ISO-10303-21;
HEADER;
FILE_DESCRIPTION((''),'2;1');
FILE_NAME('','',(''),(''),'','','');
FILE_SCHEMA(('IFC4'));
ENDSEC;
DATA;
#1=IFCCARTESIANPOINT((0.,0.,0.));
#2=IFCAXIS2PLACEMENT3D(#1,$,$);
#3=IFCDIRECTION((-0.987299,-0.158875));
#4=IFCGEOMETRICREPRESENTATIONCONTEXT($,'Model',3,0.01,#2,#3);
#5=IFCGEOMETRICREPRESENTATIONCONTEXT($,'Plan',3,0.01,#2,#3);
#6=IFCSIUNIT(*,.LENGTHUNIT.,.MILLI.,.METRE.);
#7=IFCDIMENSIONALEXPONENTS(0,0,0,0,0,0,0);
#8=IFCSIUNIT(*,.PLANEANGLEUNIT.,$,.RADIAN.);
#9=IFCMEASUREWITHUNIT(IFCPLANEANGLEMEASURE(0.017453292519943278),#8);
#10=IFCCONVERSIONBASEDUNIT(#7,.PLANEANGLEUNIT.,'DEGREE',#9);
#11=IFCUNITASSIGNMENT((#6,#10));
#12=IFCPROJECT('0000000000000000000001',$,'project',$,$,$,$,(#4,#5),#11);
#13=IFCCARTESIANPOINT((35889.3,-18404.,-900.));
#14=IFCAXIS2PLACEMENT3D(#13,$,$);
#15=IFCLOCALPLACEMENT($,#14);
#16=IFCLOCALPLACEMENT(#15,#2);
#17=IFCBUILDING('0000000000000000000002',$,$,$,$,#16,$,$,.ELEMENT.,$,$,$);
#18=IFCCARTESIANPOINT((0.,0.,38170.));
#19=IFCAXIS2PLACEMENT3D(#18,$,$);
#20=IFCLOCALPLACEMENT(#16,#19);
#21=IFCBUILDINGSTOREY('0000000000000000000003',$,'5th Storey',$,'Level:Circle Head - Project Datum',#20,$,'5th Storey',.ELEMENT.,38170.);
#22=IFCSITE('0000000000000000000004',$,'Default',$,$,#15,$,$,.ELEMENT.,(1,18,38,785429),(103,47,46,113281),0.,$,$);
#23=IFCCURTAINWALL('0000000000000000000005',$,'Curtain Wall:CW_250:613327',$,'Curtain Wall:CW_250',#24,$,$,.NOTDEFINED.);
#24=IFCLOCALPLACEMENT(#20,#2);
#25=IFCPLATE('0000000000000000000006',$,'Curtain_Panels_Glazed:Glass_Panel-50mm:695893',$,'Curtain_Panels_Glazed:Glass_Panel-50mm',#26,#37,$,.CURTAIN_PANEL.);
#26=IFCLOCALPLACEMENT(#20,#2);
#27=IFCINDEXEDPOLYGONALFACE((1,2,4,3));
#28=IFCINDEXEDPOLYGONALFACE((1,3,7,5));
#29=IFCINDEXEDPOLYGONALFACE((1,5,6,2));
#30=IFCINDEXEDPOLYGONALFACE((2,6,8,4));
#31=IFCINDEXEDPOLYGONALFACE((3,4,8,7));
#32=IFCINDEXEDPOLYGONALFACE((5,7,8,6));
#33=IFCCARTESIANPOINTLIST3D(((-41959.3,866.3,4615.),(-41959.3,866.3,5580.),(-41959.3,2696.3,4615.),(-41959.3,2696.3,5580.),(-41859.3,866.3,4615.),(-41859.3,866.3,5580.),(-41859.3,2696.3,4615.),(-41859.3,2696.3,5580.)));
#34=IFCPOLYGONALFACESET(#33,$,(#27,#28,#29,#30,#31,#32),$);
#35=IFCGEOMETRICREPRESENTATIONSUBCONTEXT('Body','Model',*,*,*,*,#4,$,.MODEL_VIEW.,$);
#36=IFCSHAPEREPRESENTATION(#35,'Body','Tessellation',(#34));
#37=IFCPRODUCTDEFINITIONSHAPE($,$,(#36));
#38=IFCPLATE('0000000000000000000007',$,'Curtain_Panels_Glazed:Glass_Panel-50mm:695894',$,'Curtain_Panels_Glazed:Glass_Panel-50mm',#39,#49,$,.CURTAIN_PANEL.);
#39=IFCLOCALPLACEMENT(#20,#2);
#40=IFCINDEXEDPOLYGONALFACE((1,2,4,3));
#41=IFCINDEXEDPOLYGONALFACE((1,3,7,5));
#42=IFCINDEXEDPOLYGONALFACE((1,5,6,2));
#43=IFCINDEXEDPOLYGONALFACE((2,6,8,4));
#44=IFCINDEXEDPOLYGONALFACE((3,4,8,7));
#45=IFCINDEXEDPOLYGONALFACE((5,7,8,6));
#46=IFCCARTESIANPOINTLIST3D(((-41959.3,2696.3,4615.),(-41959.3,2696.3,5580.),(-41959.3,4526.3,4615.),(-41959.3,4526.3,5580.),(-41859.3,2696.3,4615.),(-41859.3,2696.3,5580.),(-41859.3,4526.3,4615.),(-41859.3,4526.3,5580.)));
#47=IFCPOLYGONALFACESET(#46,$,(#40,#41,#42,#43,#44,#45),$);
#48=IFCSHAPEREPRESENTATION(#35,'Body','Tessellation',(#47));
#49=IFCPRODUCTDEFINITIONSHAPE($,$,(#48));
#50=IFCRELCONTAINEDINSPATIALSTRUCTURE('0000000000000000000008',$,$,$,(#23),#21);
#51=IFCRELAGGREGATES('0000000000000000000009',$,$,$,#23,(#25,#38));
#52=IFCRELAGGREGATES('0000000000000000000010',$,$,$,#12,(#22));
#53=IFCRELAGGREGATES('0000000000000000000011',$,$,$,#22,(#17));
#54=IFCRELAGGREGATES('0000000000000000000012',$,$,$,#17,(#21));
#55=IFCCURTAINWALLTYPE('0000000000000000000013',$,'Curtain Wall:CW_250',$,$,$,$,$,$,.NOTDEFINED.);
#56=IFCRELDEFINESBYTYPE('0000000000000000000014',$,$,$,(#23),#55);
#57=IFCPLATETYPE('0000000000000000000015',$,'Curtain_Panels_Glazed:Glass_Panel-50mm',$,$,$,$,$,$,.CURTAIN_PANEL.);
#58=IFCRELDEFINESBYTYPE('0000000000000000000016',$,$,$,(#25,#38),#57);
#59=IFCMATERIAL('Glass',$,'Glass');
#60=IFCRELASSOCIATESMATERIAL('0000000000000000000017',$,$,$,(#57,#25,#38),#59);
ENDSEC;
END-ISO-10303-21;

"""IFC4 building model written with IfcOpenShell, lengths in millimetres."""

from ifc_helpers import new_model, entity, si_unit, converted_unit, direction, frame, origin, place, context, subcontext, project, spatial, indexed_curve, outline, extrude, source, transform, mapped, material, type_object, type_shapes, element, aggregate, save


model = new_model("IFC4")

# Units and contexts
model_context = context("Model", 3, precision=0.01, world=origin(), true_north=direction((-0.987299, -0.158875)))
plan_context = context("Plan", 3, precision=0.01, world=origin(), true_north=direction((-0.987299, -0.158875)))
body_context = subcontext(model_context, "Body", "Model", "MODEL_VIEW")
ifc_project = project(units=[si_unit("LENGTHUNIT", "METRE", prefix="MILLI"), converted_unit("PLANEANGLEUNIT", "DEGREE", entity("IfcPlaneAngleMeasure", 0.017453292519943278), si_unit("PLANEANGLEUNIT", "RADIAN"), dimensions=[0, 0, 0, 0, 0, 0, 0])], contexts=[model_context, plan_context])

# Site, building, storey
site_placement = place(None, frame((35889.3, -18404.0, -900.0)))
site = spatial("IfcSite", under=ifc_project, at=site_placement, Name="Default", CompositionType="ELEMENT", RefLatitude=(1, 18, 38, 785429), RefLongitude=(103, 47, 46, 113281), RefElevation=0.0)
building_placement = place(site_placement, origin())
building = spatial("IfcBuilding", under=site, at=building_placement, CompositionType="ELEMENT")
storey_placement = place(building_placement, frame((0.0, 0.0, 38170.0)))
storey = spatial("IfcBuildingStorey", under=building, at=storey_placement, Name="5th Storey", ObjectType="Level:Circle Head - Project Datum", LongName="5th Storey", CompositionType="ELEMENT", Elevation=38170.0)

# Curtain wall
curtain_wall_type = type_object("IfcCurtainWallType", Name="Curtain Wall:CW_250", PredefinedType="NOTDEFINED")
curtain_wall_1_placement = place(storey_placement, frame((0.0, 0.0, -38170.0)))
curtain_wall_1 = element("IfcCurtainWall", 1, at=curtain_wall_1_placement, inside=storey, type_object=curtain_wall_type, Name="Curtain Wall:CW_250:613327", ObjectType="Curtain Wall:CW_250", PredefinedType="NOTDEFINED")

# Plates
ifc_material_1 = material(Name="Glass", Category="Glass")
plate_type_1 = type_object("IfcPlateType", Name="Curtain_Panels_Glazed:Glass_Panel-50mm", PredefinedType="CURTAIN_PANEL", material=ifc_material_1)
shared_shape_1 = source(origin(), body_context, "Body", "SweptSolid", [
    extrude(outline(indexed_curve([(-50.0, -915.0), (50.0, -915.0), (50.0, 915.0), (-50.0, 915.0), (-50.0, -915.0)], self_intersect=False)), frame((0.0, 200.0, 0.0), z_axis=(0.0, 0.0, 1.0), x_axis=(0.0, 1.0, 0.0)), (0.0, 0.0, 1.0), 965.0),
])
type_shapes(plate_type_1, [shared_shape_1])
plate_1_placement = place(curtain_wall_1_placement, frame((-41709.3, 1781.3, 42785.0), z_axis=(0.0, 0.0, 1.0), x_axis=(0.0, 1.0, 0.0)))
plate_1 = element("IfcPlate", 2, at=plate_1_placement, type_object=plate_type_1, material=ifc_material_1, Name="Curtain_Panels_Glazed:Glass_Panel-50mm:695893", ObjectType="Curtain_Panels_Glazed:Glass_Panel-50mm", PredefinedType="CURTAIN_PANEL", context=body_context, shape_type="MappedRepresentation", body=[
    mapped(shared_shape_1, transform((0.0, 0.0, 0.0), scale=1.0)),
])
plate_2_placement = place(curtain_wall_1_placement, frame((-41709.3, 3611.3, 42785.0), z_axis=(0.0, 0.0, 1.0), x_axis=(0.0, 1.0, 0.0)))
plate_2 = element("IfcPlate", 3, at=plate_2_placement, type_object=plate_type_1, material=ifc_material_1, Name="Curtain_Panels_Glazed:Glass_Panel-50mm:695894", ObjectType="Curtain_Panels_Glazed:Glass_Panel-50mm", PredefinedType="CURTAIN_PANEL", context=body_context, shape_type="MappedRepresentation", body=[
    mapped(shared_shape_1, transform((0.0, 0.0, 0.0), scale=1.0)),
])
aggregate(curtain_wall_1, [plate_1, plate_2])

save(model, "model.ifc")
